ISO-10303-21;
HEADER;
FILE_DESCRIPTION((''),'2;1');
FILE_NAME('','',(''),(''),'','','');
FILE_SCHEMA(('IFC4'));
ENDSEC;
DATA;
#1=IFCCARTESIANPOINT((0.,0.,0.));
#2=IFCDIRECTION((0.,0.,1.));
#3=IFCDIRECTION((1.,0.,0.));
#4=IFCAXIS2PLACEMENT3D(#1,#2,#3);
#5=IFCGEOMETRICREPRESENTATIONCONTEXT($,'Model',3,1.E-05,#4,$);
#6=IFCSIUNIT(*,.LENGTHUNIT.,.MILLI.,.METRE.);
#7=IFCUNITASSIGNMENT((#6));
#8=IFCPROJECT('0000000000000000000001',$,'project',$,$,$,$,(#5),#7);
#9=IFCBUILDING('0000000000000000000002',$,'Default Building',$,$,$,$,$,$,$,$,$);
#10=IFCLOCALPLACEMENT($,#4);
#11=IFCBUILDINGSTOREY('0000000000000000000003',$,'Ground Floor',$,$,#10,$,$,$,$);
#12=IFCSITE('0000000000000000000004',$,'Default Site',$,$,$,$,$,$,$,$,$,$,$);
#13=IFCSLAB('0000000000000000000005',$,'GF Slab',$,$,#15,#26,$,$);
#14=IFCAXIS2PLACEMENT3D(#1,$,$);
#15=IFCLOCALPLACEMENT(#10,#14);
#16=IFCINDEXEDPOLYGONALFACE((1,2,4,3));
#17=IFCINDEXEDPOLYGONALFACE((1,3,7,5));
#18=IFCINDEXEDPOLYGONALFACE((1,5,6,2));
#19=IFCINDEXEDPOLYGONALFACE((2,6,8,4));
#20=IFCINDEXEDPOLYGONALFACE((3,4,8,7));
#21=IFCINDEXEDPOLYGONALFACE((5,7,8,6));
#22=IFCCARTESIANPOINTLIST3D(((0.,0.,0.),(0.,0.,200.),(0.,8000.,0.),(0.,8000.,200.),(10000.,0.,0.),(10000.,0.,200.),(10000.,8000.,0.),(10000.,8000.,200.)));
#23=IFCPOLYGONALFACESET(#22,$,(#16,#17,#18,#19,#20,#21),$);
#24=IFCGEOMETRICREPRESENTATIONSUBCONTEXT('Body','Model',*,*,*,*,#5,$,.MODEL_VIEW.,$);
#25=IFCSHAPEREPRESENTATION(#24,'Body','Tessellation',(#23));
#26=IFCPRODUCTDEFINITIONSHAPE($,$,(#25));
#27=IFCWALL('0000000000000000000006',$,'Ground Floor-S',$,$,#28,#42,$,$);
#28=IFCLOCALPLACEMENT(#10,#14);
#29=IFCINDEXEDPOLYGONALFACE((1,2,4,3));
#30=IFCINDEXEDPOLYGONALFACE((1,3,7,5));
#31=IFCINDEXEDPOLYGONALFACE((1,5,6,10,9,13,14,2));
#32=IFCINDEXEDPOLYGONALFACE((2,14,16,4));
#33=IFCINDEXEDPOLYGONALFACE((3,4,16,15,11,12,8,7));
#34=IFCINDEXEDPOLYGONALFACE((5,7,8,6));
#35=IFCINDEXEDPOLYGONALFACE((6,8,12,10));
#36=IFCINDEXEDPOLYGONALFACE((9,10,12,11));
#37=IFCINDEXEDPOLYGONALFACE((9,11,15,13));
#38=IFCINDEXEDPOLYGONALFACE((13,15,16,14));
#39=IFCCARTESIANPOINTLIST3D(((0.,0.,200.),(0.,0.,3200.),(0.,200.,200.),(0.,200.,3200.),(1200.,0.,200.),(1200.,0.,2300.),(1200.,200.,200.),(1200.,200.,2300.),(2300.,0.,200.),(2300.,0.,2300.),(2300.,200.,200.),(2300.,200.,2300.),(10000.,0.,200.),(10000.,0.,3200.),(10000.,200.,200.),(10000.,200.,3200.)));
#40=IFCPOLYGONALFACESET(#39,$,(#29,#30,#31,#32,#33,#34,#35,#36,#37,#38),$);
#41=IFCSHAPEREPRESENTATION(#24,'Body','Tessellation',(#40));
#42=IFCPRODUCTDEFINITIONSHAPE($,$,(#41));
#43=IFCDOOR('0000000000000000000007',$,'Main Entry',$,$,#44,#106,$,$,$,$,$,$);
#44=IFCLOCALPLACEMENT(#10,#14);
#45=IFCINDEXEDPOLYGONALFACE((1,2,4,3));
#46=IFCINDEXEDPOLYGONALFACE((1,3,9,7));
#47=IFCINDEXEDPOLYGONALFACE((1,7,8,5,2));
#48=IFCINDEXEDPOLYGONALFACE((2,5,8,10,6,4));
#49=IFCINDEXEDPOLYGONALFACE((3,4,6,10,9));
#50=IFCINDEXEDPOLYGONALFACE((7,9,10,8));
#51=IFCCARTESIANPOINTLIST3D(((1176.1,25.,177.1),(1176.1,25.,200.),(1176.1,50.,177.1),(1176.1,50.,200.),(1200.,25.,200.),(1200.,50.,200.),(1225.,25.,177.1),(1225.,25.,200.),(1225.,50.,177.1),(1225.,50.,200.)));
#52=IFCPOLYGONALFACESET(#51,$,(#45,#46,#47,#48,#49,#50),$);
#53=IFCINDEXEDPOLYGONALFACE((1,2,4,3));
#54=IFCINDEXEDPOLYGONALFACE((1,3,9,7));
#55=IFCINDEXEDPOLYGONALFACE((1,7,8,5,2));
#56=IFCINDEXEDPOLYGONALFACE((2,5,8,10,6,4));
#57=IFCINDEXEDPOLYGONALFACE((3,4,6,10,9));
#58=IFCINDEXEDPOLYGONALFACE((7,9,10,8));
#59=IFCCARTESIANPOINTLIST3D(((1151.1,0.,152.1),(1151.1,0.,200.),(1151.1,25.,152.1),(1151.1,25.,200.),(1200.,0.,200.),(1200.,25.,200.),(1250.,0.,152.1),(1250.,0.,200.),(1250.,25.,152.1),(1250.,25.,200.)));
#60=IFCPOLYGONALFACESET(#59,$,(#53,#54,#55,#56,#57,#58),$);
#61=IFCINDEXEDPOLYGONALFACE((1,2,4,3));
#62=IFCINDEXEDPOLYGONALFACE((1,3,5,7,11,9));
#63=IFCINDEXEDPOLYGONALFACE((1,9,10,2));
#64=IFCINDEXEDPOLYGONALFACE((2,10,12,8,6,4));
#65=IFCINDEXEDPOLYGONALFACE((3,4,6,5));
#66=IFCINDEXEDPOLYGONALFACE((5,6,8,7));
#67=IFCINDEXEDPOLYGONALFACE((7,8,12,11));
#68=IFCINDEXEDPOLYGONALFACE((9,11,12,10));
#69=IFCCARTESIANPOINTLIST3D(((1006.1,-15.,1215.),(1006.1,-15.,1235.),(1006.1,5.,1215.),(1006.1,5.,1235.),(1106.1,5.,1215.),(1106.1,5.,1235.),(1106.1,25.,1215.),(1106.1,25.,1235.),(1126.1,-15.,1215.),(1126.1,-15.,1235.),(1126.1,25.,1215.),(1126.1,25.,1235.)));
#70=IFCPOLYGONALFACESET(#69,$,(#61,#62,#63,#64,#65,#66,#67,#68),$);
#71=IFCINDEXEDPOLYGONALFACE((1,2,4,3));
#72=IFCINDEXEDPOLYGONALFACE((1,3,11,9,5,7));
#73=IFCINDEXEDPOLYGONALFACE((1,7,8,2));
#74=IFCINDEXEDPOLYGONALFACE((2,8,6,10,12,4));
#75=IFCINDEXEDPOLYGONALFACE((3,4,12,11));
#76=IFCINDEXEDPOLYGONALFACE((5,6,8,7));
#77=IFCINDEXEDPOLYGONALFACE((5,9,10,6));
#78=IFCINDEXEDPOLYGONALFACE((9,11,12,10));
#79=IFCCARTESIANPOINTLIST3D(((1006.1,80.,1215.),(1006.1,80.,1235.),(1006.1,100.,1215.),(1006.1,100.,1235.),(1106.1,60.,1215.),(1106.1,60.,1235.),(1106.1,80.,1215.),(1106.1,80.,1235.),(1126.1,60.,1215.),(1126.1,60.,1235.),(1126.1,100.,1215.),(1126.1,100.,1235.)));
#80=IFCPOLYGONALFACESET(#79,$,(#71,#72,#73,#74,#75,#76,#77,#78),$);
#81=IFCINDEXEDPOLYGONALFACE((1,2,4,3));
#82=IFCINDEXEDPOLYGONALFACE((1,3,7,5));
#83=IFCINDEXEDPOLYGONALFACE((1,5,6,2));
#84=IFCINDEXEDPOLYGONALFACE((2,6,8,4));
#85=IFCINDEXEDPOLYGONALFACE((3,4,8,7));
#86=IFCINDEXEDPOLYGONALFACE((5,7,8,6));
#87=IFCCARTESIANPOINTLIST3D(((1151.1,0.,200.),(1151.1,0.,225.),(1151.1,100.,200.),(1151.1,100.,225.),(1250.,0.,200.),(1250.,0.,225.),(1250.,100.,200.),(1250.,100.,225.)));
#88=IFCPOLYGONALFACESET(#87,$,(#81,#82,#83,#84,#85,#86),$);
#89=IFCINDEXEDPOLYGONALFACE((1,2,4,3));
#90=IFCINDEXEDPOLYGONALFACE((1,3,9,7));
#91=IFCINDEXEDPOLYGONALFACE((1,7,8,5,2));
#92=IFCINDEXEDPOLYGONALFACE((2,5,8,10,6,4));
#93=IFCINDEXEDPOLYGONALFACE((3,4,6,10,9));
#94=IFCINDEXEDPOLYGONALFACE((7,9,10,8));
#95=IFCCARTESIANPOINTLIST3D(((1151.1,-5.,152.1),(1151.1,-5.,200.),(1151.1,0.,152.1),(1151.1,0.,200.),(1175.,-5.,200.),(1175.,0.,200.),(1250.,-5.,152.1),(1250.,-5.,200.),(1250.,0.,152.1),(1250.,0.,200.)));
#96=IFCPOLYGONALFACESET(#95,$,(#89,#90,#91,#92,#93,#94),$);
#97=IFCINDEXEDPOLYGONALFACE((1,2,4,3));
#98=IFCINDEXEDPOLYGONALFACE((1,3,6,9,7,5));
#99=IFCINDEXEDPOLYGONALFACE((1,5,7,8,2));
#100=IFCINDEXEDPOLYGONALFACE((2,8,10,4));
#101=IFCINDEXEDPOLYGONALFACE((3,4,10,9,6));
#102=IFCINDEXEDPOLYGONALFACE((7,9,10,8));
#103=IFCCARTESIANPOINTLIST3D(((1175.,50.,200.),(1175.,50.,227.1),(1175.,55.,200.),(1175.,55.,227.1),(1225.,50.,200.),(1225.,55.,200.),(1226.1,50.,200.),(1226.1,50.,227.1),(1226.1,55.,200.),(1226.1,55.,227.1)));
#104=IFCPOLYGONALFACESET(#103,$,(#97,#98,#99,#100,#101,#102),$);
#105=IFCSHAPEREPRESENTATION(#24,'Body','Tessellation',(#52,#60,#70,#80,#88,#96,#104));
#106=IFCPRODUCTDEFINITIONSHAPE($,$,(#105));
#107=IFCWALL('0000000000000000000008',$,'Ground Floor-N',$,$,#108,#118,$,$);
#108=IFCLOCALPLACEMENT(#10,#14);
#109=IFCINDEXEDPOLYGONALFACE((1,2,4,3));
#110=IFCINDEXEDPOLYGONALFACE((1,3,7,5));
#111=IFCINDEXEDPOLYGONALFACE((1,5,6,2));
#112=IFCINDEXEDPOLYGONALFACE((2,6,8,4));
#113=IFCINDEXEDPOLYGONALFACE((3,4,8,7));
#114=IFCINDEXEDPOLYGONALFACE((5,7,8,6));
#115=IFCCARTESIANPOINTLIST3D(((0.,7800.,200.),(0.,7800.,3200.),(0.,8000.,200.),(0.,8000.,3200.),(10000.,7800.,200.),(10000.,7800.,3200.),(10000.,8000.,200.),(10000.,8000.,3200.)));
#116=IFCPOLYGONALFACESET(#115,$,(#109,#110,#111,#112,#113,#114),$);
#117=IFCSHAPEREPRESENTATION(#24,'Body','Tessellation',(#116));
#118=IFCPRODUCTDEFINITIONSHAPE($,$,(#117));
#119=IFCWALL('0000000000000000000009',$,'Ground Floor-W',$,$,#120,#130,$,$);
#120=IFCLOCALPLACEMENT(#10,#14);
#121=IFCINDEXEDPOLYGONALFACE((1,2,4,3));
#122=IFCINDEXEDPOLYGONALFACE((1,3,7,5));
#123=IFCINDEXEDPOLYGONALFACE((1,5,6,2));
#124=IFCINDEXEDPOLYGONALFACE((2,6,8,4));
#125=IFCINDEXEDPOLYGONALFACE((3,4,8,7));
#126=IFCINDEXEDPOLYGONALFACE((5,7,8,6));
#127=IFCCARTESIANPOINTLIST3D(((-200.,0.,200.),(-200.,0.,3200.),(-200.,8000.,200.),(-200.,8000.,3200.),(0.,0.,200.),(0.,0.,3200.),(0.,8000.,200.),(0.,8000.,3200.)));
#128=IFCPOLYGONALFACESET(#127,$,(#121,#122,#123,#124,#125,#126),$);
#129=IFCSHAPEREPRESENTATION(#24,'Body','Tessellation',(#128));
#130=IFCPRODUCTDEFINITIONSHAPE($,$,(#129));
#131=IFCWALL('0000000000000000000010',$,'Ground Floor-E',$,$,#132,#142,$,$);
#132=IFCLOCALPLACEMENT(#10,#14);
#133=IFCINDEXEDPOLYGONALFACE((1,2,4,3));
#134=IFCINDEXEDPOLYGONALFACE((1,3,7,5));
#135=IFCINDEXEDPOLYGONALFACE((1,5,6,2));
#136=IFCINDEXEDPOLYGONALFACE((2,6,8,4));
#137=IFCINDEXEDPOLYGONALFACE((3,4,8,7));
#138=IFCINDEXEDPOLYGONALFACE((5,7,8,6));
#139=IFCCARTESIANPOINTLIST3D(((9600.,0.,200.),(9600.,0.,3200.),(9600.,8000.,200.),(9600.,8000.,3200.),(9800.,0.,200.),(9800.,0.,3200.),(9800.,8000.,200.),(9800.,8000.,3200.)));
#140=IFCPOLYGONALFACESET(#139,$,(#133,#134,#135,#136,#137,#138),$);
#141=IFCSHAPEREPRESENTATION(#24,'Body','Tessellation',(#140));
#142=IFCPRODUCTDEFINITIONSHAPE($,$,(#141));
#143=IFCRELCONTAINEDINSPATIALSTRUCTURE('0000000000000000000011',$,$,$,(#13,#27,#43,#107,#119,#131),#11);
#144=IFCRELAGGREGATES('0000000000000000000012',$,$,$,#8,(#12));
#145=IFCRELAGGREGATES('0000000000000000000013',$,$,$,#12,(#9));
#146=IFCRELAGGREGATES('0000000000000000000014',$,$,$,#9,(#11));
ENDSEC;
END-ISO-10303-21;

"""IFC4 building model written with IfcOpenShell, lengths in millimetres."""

from ifc_helpers import new_model, si_unit, frame, origin_with_axes, place, context, subcontext, project, spatial, line, indexed_curve, outline, extrude, element, fill, save


model = new_model("IFC4")

# Units and contexts
model_context = context("Model", 3, precision=1e-05, world=origin_with_axes())
body_context = subcontext(model_context, "Body", "Model", "MODEL_VIEW")
ifc_project = project(units=[si_unit("LENGTHUNIT", "METRE", prefix="MILLI")], contexts=[model_context])

# Site, building, storey
site = spatial("IfcSite", under=ifc_project, Name="Default Site")
building = spatial("IfcBuilding", under=site, Name="Default Building")
storey_placement = place(None, origin_with_axes())
storey = spatial("IfcBuildingStorey", under=building, at=storey_placement, Name="Ground Floor")

# Slab
slab_placement = place(storey_placement, origin_with_axes())
element("IfcSlab", 1, at=slab_placement, inside=storey, Name="GF Slab", context=body_context, shape_type="SweptSolid", body=[
    extrude(outline(indexed_curve([(0.0, 0.0), (10000.0, 0.0), (10000.0, 8000.0), (0.0, 8000.0), (0.0, 0.0)])), None, (0.0, 0.0, 1.0), 200.0),
])

# Wall, opening, door
wall_1_placement = place(storey_placement, frame((0.0, 0.0, 200.0), z_axis=(0.0, 0.0, 1.0), x_axis=(1.0, 0.0, 0.0)))
wall_1 = element("IfcWall", 2, at=wall_1_placement, inside=storey, Name="Ground Floor-S", context=body_context, shape_type="SweptSolid", body=[
    extrude(outline(indexed_curve([(0.0, 0.0), (10000.0, 0.0), (10000.0, 200.0), (0.0, 200.0), (0.0, 0.0)])), None, (0.0, 0.0, 1.0), 3000.0),
])
opening_placement = place(wall_1_placement, origin_with_axes())
opening = element("IfcOpeningElement", 3, at=opening_placement, cuts=wall_1, context=body_context, shape_type="SweptSolid", body=[
    extrude(outline(indexed_curve([(1200.0, 0.0), (2300.0, 0.0), (2300.0, 200.0), (1200.0, 200.0), (1200.0, 0.0)])), None, (0.0, 0.0, 1.0), 2100.0),
])
door_placement = place(storey_placement, frame((1200.0, 0.0, 200.0), z_axis=(0.0, 0.0, 1.0), x_axis=(1.0, 0.0, 0.0)))
door = element("IfcDoor", 4, at=door_placement, inside=storey, Name="Main Entry", context=body_context, shape_type="SweptSolid", body=[
    extrude(outline(indexed_curve([(0.0, 0.0), (0.0, 2.1), (1.1, 2.1), (1.1, 0.0), (-23.9, 0.0), (-23.9, -22.9), (25.0, -22.9), (25.0, 0.0)], segments=[line(1, 2, 3, 4, 5, 6, 7, 8, 1)])), frame((0.0, 25.0, 0.0), z_axis=(0.0, -1.0, 0.0), x_axis=(1.0, 0.0, 0.0)), (0.0, 0.0, -1.0), 25.0),
    extrude(outline(indexed_curve([(0.0, 0.0), (0.0, 2.1), (1.1, 2.1), (1.1, 0.0), (-48.9, 0.0), (-48.9, -47.9), (50.0, -47.9), (50.0, 0.0)], segments=[line(1, 2, 3, 4, 5, 6, 7, 8, 1)])), frame((0.0, 0.0, 0.0), z_axis=(0.0, -1.0, 0.0), x_axis=(1.0, 0.0, 0.0)), (0.0, 0.0, -1.0), 25.0),
    extrude(outline(indexed_curve([(0.0, 0.0), (-48.9, 0.0), (-48.9, 35.0), (0.0, 35.0)], segments=[line(1, 2, 3, 4, 1)])), frame((25.0, 25.0, 25.0), z_axis=(0.0, 0.0, 1.0), x_axis=(1.0, 0.0, 0.0)), (0.0, 0.0, 1.0), -47.9),
    extrude(outline(indexed_curve([(0.0, 0.0), (0.0, -40.0), (-120.0, -40.0), (-120.0, -20.0), (-20.0, -20.0), (-20.0, 0.0)], segments=[line(1, 2, 3, 4, 5, 6, 1)])), frame((-73.9, 25.0, 1015.0), z_axis=(0.0, 0.0, 1.0), x_axis=(1.0, 0.0, 0.0)), (0.0, 0.0, 1.0), 20.0),
    extrude(outline(indexed_curve([(0.0, 0.0), (0.0, 40.0), (-120.0, 40.0), (-120.0, 20.0), (-20.0, 20.0), (-20.0, 0.0)], segments=[line(1, 2, 3, 4, 5, 6, 1)])), frame((-73.9, 60.0, 1015.0), z_axis=(0.0, 0.0, 1.0), x_axis=(1.0, 0.0, 0.0)), (0.0, 0.0, 1.0), 20.0),
    extrude(outline(indexed_curve([(0.0, 0.0), (-98.9, 0.0), (-98.9, 100.0), (0.0, 100.0)], segments=[line(1, 2, 3, 4, 1)])), frame((50.0, 0.0, 0.0), z_axis=(0.0, 0.0, 1.0), x_axis=(1.0, 0.0, 0.0)), (0.0, 0.0, 1.0), 25.0),
    extrude(outline(indexed_curve([(0.0, 0.0), (0.0, 27.1), (51.1, 27.1), (51.1, 0.0), (-23.9, 0.0), (-23.9, -47.9), (75.0, -47.9), (75.0, 0.0)], segments=[line(1, 2, 3, 4, 5, 6, 7, 8, 1)])), frame((-25.0, -5.0, 0.0), z_axis=(0.0, -1.0, 0.0), x_axis=(1.0, 0.0, 0.0)), (0.0, 0.0, -1.0), 5.0),
    extrude(outline(indexed_curve([(0.0, 0.0), (0.0, 27.1), (51.1, 27.1), (51.1, 0.0), (1.1, 0.0), (1.1, -22.9), (50.0, -22.9), (50.0, 0.0)], segments=[line(1, 2, 3, 4, 5, 6, 7, 8, 1)])), frame((-25.0, 50.0, 0.0), z_axis=(0.0, -1.0, 0.0), x_axis=(1.0, 0.0, 0.0)), (0.0, 0.0, -1.0), 5.0),
])
fill(opening, door)

# Walls
wall_2_placement = place(storey_placement, frame((0.0, 0.0, 200.0), z_axis=(0.0, 0.0, 1.0), x_axis=(1.0, 0.0, 0.0)))
element("IfcWall", 5, at=wall_2_placement, inside=storey, Name="Ground Floor-N", context=body_context, shape_type="SweptSolid", body=[
    extrude(outline(indexed_curve([(0.0, 7800.0), (10000.0, 7800.0), (10000.0, 8000.0), (0.0, 8000.0), (0.0, 7800.0)])), None, (0.0, 0.0, 1.0), 3000.0),
])
wall_3_placement = place(storey_placement, frame((0.0, 0.0, 200.0), z_axis=(0.0, 0.0, 1.0), x_axis=(1.0, 0.0, 0.0)))
element("IfcWall", 6, at=wall_3_placement, inside=storey, Name="Ground Floor-W", context=body_context, shape_type="SweptSolid", body=[
    extrude(outline(indexed_curve([(0.0, 0.0), (0.0, 8000.0), (-200.0, 8000.0), (-200.0, 0.0), (0.0, 0.0)])), None, (0.0, 0.0, 1.0), 3000.0),
])
wall_4_placement = place(storey_placement, frame((0.0, 0.0, 200.0), z_axis=(0.0, 0.0, 1.0), x_axis=(1.0, 0.0, 0.0)))
element("IfcWall", 7, at=wall_4_placement, inside=storey, Name="Ground Floor-E", context=body_context, shape_type="SweptSolid", body=[
    extrude(outline(indexed_curve([(9800.0, 0.0), (9800.0, 8000.0), (9600.0, 8000.0), (9600.0, 0.0), (9800.0, 0.0)])), None, (0.0, 0.0, 1.0), 3000.0),
])

save(model, "model.ifc")
